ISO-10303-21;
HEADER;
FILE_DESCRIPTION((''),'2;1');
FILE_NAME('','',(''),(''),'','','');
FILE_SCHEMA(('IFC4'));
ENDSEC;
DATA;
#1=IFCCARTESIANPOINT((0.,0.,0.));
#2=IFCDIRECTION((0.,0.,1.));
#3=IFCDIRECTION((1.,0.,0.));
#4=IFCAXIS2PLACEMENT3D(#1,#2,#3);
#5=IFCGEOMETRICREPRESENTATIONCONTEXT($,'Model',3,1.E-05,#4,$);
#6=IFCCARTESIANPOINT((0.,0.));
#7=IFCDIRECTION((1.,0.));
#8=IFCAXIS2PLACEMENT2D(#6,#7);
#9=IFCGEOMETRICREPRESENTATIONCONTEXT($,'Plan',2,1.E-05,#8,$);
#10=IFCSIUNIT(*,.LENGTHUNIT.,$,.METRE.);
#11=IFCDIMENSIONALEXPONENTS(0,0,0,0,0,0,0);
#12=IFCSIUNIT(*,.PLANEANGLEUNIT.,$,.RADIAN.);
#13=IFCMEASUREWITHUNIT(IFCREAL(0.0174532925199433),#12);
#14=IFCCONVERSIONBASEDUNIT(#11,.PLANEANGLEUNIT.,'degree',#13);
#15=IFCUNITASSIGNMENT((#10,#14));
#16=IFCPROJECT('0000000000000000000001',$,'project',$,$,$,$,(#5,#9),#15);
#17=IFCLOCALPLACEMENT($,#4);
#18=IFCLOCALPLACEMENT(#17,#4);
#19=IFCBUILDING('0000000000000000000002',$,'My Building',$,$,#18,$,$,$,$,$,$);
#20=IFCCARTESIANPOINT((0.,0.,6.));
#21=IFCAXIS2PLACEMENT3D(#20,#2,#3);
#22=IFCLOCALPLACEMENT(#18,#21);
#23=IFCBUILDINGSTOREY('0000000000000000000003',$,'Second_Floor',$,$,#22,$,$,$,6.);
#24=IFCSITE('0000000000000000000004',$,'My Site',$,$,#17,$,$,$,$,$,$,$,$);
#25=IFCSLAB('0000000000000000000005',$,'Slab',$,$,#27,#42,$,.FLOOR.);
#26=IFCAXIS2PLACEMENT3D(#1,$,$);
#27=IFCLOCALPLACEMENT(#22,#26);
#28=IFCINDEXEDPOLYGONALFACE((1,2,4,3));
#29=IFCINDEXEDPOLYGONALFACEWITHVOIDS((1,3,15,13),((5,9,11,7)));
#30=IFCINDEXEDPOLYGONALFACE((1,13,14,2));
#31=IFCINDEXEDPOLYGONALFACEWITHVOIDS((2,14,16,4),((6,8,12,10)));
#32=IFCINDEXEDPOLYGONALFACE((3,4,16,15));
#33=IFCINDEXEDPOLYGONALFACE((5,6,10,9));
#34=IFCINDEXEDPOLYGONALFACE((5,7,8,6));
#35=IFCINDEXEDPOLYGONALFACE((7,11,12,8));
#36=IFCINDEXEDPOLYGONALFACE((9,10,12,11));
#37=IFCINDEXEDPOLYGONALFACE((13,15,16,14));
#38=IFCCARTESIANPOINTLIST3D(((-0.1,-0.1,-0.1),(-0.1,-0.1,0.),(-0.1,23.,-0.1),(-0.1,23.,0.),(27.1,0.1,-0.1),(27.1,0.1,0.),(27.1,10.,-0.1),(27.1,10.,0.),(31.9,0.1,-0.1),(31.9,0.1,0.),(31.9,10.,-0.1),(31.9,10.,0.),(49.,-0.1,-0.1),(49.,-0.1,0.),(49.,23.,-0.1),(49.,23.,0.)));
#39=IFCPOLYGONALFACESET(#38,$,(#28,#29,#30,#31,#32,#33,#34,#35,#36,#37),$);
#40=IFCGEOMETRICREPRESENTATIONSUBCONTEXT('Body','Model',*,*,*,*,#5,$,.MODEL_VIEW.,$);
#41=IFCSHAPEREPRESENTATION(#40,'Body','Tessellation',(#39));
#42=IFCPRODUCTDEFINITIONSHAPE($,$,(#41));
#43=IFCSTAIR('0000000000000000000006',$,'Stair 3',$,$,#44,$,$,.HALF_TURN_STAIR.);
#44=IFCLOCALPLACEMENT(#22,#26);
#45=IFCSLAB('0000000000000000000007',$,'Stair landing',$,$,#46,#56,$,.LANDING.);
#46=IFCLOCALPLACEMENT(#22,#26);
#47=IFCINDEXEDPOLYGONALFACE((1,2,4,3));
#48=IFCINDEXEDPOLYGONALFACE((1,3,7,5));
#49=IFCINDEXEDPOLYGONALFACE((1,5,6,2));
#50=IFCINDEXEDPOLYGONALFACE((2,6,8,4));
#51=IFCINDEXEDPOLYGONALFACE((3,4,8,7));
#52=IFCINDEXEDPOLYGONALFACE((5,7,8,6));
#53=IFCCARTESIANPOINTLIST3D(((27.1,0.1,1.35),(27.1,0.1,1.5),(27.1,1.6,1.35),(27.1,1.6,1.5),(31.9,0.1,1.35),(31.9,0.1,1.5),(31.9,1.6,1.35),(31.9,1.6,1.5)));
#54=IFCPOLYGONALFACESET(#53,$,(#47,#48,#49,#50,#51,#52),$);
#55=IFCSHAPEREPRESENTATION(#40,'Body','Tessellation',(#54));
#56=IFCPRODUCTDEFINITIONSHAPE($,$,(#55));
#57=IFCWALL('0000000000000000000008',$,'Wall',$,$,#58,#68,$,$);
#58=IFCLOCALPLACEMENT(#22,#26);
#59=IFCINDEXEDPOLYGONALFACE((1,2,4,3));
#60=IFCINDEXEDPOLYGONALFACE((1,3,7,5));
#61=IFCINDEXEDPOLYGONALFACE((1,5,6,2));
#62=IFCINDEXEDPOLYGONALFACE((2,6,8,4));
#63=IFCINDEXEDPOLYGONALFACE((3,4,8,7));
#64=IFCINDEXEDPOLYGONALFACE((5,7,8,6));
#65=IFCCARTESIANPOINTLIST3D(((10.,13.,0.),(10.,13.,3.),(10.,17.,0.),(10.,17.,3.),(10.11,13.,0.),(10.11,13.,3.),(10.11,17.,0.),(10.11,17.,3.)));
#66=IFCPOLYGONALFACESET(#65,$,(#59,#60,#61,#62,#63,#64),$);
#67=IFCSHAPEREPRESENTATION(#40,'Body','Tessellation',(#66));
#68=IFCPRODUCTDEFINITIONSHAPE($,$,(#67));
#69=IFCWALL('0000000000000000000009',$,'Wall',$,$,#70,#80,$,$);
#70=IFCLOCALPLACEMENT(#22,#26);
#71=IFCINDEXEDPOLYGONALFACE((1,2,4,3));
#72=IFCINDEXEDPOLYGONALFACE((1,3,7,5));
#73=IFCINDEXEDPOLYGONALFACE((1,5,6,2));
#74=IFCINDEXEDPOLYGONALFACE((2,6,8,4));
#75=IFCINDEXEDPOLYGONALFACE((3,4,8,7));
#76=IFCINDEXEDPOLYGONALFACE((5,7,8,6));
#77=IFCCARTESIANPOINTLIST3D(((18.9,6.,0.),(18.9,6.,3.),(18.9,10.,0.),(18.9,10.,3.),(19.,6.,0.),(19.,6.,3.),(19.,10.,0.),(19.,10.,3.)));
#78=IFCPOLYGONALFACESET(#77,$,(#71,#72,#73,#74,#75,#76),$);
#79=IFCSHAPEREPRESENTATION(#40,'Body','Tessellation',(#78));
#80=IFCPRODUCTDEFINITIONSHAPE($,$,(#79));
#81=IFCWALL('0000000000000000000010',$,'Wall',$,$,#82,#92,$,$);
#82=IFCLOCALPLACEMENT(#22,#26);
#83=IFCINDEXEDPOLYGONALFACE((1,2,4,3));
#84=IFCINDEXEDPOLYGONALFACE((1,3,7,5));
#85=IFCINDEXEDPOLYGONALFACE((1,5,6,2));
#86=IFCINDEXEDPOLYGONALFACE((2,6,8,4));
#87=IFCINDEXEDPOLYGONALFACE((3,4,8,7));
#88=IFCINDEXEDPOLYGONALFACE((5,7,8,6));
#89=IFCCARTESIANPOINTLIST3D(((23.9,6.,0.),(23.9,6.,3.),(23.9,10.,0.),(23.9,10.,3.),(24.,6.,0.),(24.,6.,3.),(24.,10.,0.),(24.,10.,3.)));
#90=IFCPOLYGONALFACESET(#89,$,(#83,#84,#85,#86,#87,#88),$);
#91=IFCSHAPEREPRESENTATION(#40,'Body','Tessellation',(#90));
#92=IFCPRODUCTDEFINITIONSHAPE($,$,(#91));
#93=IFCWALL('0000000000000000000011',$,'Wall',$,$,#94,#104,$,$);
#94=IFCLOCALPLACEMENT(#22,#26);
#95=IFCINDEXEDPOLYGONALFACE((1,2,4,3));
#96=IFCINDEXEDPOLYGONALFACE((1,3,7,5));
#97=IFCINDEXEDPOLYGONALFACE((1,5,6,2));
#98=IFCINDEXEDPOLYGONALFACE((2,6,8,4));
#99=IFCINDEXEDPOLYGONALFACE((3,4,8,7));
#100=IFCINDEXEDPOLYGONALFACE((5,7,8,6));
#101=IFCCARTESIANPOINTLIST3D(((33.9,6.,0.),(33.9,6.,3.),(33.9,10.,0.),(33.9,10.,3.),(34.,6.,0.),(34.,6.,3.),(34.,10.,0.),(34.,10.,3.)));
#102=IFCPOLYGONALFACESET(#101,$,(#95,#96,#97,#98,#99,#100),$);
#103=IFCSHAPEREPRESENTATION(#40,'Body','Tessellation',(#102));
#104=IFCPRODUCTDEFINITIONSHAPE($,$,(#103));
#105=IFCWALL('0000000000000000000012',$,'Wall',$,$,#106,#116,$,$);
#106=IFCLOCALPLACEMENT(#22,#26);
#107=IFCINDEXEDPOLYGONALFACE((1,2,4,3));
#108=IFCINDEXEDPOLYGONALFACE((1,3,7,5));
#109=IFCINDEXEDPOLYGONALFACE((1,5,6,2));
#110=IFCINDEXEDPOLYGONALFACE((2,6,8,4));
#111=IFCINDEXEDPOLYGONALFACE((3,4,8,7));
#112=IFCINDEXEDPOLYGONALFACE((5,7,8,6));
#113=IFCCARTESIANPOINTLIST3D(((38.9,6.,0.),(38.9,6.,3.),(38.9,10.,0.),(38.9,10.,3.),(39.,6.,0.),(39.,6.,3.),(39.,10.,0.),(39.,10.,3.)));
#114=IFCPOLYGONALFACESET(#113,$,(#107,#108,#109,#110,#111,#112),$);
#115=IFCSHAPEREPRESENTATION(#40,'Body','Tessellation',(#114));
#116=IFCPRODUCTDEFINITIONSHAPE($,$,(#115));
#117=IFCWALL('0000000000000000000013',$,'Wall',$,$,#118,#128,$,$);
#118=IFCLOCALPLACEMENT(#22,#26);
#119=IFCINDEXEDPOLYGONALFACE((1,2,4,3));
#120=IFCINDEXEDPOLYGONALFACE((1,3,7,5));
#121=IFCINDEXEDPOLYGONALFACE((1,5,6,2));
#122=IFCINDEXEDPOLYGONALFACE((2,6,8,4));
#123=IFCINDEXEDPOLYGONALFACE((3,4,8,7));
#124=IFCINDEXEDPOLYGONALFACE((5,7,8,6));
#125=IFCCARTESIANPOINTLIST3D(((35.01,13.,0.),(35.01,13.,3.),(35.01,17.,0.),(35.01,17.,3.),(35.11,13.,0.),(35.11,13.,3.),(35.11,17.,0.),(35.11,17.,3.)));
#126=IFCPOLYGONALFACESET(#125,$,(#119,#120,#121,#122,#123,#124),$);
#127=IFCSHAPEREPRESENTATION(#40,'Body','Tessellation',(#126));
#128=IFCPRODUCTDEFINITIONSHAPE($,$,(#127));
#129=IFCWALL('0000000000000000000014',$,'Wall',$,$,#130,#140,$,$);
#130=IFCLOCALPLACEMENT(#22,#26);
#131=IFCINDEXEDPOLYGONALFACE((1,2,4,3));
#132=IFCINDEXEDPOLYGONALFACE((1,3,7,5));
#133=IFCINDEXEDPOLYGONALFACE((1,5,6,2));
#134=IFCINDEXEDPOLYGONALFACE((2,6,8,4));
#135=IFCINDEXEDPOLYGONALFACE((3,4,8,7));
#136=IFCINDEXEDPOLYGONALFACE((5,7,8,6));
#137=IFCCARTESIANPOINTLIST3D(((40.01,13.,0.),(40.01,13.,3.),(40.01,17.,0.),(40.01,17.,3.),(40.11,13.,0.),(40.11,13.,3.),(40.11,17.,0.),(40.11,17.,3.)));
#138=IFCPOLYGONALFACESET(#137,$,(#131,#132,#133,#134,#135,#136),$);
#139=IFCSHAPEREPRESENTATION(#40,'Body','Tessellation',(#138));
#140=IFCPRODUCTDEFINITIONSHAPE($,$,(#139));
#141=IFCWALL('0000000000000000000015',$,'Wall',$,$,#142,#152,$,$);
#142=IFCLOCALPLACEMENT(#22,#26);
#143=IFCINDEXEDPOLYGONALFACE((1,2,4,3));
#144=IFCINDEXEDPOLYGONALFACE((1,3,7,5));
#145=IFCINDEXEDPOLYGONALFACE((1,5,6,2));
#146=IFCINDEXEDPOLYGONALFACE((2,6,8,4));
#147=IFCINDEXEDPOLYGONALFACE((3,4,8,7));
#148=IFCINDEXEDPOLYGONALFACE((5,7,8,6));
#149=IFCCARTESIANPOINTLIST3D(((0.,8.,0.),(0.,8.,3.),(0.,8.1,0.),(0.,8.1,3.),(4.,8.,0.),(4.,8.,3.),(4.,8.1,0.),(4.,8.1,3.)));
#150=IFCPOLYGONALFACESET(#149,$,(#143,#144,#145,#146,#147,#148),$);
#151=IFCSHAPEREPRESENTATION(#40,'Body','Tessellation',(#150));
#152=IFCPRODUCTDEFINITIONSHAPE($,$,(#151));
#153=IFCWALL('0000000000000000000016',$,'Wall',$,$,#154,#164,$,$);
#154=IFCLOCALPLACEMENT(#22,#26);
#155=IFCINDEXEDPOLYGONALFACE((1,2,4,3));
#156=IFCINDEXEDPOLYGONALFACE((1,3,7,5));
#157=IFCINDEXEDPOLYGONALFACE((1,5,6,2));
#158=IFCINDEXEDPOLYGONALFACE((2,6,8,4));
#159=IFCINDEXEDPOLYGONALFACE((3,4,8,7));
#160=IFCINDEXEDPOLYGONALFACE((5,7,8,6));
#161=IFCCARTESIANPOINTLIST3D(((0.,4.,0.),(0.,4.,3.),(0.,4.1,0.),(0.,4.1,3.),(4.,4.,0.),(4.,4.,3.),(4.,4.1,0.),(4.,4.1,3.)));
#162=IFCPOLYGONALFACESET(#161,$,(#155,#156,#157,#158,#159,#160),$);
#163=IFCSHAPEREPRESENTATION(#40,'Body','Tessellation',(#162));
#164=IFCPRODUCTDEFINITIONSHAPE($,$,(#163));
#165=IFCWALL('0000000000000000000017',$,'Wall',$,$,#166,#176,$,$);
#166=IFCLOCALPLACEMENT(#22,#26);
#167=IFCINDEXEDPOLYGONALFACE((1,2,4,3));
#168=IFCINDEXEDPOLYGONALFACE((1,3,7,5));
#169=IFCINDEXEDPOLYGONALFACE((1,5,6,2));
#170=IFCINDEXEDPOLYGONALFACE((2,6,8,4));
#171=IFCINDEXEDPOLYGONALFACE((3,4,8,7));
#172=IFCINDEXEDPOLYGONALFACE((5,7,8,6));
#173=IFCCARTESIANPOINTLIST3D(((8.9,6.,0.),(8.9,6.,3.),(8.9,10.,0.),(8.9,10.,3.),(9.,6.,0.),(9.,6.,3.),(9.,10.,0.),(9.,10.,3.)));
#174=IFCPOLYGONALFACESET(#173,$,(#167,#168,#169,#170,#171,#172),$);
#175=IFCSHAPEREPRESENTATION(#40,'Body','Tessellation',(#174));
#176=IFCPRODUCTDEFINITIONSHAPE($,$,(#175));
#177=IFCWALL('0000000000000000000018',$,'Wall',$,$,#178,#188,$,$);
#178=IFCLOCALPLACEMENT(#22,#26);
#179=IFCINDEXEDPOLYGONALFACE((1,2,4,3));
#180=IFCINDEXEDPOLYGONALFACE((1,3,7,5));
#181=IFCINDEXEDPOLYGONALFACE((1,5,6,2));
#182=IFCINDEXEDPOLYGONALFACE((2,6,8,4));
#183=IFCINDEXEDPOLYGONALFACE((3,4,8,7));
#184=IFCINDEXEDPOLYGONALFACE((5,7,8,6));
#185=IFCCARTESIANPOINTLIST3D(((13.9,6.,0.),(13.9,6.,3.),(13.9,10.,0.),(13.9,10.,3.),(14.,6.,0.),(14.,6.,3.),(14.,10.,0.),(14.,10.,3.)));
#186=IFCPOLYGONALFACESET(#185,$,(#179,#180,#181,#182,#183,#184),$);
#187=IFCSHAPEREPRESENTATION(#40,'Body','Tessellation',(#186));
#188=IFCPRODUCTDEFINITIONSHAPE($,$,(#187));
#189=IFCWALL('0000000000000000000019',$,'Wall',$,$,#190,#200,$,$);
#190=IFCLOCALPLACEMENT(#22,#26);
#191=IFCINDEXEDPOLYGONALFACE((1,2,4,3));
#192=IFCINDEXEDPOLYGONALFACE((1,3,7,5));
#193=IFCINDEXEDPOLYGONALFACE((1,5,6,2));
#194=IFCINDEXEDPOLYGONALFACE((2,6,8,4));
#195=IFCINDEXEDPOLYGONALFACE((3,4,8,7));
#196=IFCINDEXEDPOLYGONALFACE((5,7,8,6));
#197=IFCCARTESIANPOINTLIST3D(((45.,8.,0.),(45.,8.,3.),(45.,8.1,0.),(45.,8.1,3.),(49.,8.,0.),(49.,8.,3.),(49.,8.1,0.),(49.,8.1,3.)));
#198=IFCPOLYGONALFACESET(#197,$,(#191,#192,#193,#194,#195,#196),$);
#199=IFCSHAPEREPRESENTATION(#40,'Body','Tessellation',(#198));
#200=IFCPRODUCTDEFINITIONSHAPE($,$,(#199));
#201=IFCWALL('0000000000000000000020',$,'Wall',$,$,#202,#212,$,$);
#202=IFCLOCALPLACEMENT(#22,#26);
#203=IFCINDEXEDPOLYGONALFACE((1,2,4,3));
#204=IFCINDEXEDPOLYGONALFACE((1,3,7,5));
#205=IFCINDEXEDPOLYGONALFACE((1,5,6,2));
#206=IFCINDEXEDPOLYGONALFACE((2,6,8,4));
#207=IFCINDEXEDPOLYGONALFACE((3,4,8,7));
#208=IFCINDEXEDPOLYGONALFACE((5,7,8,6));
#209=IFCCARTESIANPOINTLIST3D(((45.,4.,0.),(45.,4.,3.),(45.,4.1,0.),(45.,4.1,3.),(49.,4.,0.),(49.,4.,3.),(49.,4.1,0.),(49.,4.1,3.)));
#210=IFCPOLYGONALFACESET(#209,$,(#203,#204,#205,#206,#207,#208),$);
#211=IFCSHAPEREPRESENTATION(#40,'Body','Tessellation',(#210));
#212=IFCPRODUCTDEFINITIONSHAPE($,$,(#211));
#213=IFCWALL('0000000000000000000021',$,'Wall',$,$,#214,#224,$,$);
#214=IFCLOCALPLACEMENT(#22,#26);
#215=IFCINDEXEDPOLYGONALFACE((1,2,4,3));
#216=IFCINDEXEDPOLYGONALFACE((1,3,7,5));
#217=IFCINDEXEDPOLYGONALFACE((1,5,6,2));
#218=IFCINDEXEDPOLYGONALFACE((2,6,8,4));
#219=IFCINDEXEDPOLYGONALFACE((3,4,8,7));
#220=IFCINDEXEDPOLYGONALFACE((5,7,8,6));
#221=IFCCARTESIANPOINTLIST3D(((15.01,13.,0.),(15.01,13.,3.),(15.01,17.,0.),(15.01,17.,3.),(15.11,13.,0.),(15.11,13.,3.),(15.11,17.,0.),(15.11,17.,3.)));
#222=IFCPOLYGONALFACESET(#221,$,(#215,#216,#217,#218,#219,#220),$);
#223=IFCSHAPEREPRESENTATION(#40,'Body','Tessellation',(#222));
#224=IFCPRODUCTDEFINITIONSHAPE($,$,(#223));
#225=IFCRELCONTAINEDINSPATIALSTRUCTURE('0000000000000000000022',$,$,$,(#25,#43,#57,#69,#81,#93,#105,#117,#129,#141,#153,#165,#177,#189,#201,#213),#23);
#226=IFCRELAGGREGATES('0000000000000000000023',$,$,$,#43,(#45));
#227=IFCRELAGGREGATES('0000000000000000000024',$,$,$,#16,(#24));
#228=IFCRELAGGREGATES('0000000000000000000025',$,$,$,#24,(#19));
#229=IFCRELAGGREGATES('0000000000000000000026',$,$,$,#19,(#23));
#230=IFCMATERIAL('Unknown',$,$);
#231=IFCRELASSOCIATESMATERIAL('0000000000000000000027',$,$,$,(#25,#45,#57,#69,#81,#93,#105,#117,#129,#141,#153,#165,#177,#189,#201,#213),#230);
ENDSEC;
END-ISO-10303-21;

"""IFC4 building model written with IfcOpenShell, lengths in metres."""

from ifc_helpers import new_model, entity, si_unit, converted_unit, frame, frame_2d, origin, origin_with_axes, origin_2d_with_axis, place, context, subcontext, project, spatial, rectangle, extrude, material, element, aggregate, save


model = new_model("IFC4")

# Units and contexts
model_context = context("Model", 3, precision=1e-05, world=origin_with_axes())
plan_context = context("Plan", 2, precision=1e-05, world=origin_2d_with_axis())
body_context = subcontext(model_context, "Body", "Model", "MODEL_VIEW")
ifc_project = project(units=[si_unit("LENGTHUNIT", "METRE"), converted_unit("PLANEANGLEUNIT", "degree", entity("IfcReal", 0.0174532925199433), si_unit("PLANEANGLEUNIT", "RADIAN"), dimensions=[0, 0, 0, 0, 0, 0, 0])], contexts=[model_context, plan_context])

# Site, building, storey
site_placement = place(None, origin_with_axes())
site = spatial("IfcSite", under=ifc_project, at=site_placement, Name="My Site")
building_placement = place(site_placement, origin_with_axes())
building = spatial("IfcBuilding", under=site, at=building_placement, Name="My Building")
storey_placement = place(building_placement, frame((0.0, 0.0, 6.0), z_axis=(0.0, 0.0, 1.0), x_axis=(1.0, 0.0, 0.0)))
storey = spatial("IfcBuildingStorey", under=building, at=storey_placement, Name="Second_Floor", Elevation=6.0)

# Slab, opening
ifc_material = material(Name="Unknown")
slab_1_placement = place(storey_placement, origin_with_axes())
slab_1 = element("IfcSlab", 1, at=slab_1_placement, inside=storey, material=ifc_material, Name="Slab", PredefinedType="FLOOR", context=body_context, shape_type="SweptSolid", body=[
    extrude(rectangle(XDim=49.1, YDim=23.1, at=frame_2d((24.45, 11.45))), frame((0.0, 0.0, -0.1)), (0.0, 0.0, 1.0), 0.1),
])
opening_placement = place(slab_1_placement, origin_with_axes())
element("IfcOpeningElement", 2, at=opening_placement, cuts=slab_1, context=body_context, shape_type="SweptSolid", body=[
    extrude(rectangle(XDim=4.8, YDim=9.9, at=frame_2d((29.5, 5.05))), frame((0.0, 0.0, -0.25)), (0.0, 0.0, 1.0), 0.4),
])

# Stair, slab
stair_placement = place(storey_placement, origin_with_axes())
stair = element("IfcStair", 3, at=stair_placement, inside=storey, Name="Stair 3", PredefinedType="HALF_TURN_STAIR")
slab_2_placement = place(stair_placement, origin_with_axes())
slab_2 = element("IfcSlab", 4, at=slab_2_placement, material=ifc_material, Name="Stair landing", PredefinedType="LANDING", context=body_context, shape_type="SweptSolid", body=[
    extrude(rectangle(XDim=4.8, YDim=1.5, at=frame_2d((29.5, 0.85))), frame((0.0, 0.0, 1.35)), (0.0, 0.0, 1.0), 0.15),
])

# Walls
wall_1_placement = place(storey_placement, origin_with_axes())
element("IfcWall", 5, at=wall_1_placement, inside=storey, material=ifc_material, Name="Wall", context=body_context, shape_type="SweptSolid", body=[
    extrude(rectangle(XDim=0.11, YDim=4.0, at=frame_2d((10.055, 15.0))), origin(), (0.0, 0.0, 1.0), 3.0),
])
wall_2_placement = place(storey_placement, origin_with_axes())
element("IfcWall", 6, at=wall_2_placement, inside=storey, material=ifc_material, Name="Wall", context=body_context, shape_type="SweptSolid", body=[
    extrude(rectangle(XDim=0.1, YDim=4.0, at=frame_2d((18.95, 8.0))), origin(), (0.0, 0.0, 1.0), 3.0),
])
wall_3_placement = place(storey_placement, origin_with_axes())
element("IfcWall", 7, at=wall_3_placement, inside=storey, material=ifc_material, Name="Wall", context=body_context, shape_type="SweptSolid", body=[
    extrude(rectangle(XDim=0.1, YDim=4.0, at=frame_2d((23.95, 8.0))), origin(), (0.0, 0.0, 1.0), 3.0),
])
wall_4_placement = place(storey_placement, origin_with_axes())
element("IfcWall", 8, at=wall_4_placement, inside=storey, material=ifc_material, Name="Wall", context=body_context, shape_type="SweptSolid", body=[
    extrude(rectangle(XDim=0.1, YDim=4.0, at=frame_2d((33.95, 8.0))), origin(), (0.0, 0.0, 1.0), 3.0),
])
wall_5_placement = place(storey_placement, origin_with_axes())
element("IfcWall", 9, at=wall_5_placement, inside=storey, material=ifc_material, Name="Wall", context=body_context, shape_type="SweptSolid", body=[
    extrude(rectangle(XDim=0.1, YDim=4.0, at=frame_2d((38.95, 8.0))), origin(), (0.0, 0.0, 1.0), 3.0),
])
wall_6_placement = place(storey_placement, origin_with_axes())
element("IfcWall", 10, at=wall_6_placement, inside=storey, material=ifc_material, Name="Wall", context=body_context, shape_type="SweptSolid", body=[
    extrude(rectangle(XDim=0.1, YDim=4.0, at=frame_2d((35.06, 15.0))), origin(), (0.0, 0.0, 1.0), 3.0),
])
wall_7_placement = place(storey_placement, origin_with_axes())
element("IfcWall", 11, at=wall_7_placement, inside=storey, material=ifc_material, Name="Wall", context=body_context, shape_type="SweptSolid", body=[
    extrude(rectangle(XDim=0.1, YDim=4.0, at=frame_2d((40.06, 15.0))), origin(), (0.0, 0.0, 1.0), 3.0),
])
wall_8_placement = place(storey_placement, origin_with_axes())
element("IfcWall", 12, at=wall_8_placement, inside=storey, material=ifc_material, Name="Wall", context=body_context, shape_type="SweptSolid", body=[
    extrude(rectangle(XDim=4.0, YDim=0.1, at=frame_2d((2.0, 8.05))), origin(), (0.0, 0.0, 1.0), 3.0),
])
wall_9_placement = place(storey_placement, origin_with_axes())
element("IfcWall", 13, at=wall_9_placement, inside=storey, material=ifc_material, Name="Wall", context=body_context, shape_type="SweptSolid", body=[
    extrude(rectangle(XDim=4.0, YDim=0.1, at=frame_2d((2.0, 4.05))), origin(), (0.0, 0.0, 1.0), 3.0),
])
wall_10_placement = place(storey_placement, origin_with_axes())
element("IfcWall", 14, at=wall_10_placement, inside=storey, material=ifc_material, Name="Wall", context=body_context, shape_type="SweptSolid", body=[
    extrude(rectangle(XDim=0.1, YDim=4.0, at=frame_2d((8.95, 8.0))), origin(), (0.0, 0.0, 1.0), 3.0),
])
wall_11_placement = place(storey_placement, origin_with_axes())
element("IfcWall", 15, at=wall_11_placement, inside=storey, material=ifc_material, Name="Wall", context=body_context, shape_type="SweptSolid", body=[
    extrude(rectangle(XDim=0.1, YDim=4.0, at=frame_2d((13.95, 8.0))), origin(), (0.0, 0.0, 1.0), 3.0),
])
wall_12_placement = place(storey_placement, origin_with_axes())
element("IfcWall", 16, at=wall_12_placement, inside=storey, material=ifc_material, Name="Wall", context=body_context, shape_type="SweptSolid", body=[
    extrude(rectangle(XDim=4.0, YDim=0.1, at=frame_2d((47.0, 8.05))), origin(), (0.0, 0.0, 1.0), 3.0),
])
wall_13_placement = place(storey_placement, origin_with_axes())
element("IfcWall", 17, at=wall_13_placement, inside=storey, material=ifc_material, Name="Wall", context=body_context, shape_type="SweptSolid", body=[
    extrude(rectangle(XDim=4.0, YDim=0.1, at=frame_2d((47.0, 4.05))), origin(), (0.0, 0.0, 1.0), 3.0),
])
wall_14_placement = place(storey_placement, origin_with_axes())
element("IfcWall", 18, at=wall_14_placement, inside=storey, material=ifc_material, Name="Wall", context=body_context, shape_type="SweptSolid", body=[
    extrude(rectangle(XDim=0.1, YDim=4.0, at=frame_2d((15.06, 15.0))), origin(), (0.0, 0.0, 1.0), 3.0),
])

aggregate(stair, [slab_2])

save(model, "model.ifc")
